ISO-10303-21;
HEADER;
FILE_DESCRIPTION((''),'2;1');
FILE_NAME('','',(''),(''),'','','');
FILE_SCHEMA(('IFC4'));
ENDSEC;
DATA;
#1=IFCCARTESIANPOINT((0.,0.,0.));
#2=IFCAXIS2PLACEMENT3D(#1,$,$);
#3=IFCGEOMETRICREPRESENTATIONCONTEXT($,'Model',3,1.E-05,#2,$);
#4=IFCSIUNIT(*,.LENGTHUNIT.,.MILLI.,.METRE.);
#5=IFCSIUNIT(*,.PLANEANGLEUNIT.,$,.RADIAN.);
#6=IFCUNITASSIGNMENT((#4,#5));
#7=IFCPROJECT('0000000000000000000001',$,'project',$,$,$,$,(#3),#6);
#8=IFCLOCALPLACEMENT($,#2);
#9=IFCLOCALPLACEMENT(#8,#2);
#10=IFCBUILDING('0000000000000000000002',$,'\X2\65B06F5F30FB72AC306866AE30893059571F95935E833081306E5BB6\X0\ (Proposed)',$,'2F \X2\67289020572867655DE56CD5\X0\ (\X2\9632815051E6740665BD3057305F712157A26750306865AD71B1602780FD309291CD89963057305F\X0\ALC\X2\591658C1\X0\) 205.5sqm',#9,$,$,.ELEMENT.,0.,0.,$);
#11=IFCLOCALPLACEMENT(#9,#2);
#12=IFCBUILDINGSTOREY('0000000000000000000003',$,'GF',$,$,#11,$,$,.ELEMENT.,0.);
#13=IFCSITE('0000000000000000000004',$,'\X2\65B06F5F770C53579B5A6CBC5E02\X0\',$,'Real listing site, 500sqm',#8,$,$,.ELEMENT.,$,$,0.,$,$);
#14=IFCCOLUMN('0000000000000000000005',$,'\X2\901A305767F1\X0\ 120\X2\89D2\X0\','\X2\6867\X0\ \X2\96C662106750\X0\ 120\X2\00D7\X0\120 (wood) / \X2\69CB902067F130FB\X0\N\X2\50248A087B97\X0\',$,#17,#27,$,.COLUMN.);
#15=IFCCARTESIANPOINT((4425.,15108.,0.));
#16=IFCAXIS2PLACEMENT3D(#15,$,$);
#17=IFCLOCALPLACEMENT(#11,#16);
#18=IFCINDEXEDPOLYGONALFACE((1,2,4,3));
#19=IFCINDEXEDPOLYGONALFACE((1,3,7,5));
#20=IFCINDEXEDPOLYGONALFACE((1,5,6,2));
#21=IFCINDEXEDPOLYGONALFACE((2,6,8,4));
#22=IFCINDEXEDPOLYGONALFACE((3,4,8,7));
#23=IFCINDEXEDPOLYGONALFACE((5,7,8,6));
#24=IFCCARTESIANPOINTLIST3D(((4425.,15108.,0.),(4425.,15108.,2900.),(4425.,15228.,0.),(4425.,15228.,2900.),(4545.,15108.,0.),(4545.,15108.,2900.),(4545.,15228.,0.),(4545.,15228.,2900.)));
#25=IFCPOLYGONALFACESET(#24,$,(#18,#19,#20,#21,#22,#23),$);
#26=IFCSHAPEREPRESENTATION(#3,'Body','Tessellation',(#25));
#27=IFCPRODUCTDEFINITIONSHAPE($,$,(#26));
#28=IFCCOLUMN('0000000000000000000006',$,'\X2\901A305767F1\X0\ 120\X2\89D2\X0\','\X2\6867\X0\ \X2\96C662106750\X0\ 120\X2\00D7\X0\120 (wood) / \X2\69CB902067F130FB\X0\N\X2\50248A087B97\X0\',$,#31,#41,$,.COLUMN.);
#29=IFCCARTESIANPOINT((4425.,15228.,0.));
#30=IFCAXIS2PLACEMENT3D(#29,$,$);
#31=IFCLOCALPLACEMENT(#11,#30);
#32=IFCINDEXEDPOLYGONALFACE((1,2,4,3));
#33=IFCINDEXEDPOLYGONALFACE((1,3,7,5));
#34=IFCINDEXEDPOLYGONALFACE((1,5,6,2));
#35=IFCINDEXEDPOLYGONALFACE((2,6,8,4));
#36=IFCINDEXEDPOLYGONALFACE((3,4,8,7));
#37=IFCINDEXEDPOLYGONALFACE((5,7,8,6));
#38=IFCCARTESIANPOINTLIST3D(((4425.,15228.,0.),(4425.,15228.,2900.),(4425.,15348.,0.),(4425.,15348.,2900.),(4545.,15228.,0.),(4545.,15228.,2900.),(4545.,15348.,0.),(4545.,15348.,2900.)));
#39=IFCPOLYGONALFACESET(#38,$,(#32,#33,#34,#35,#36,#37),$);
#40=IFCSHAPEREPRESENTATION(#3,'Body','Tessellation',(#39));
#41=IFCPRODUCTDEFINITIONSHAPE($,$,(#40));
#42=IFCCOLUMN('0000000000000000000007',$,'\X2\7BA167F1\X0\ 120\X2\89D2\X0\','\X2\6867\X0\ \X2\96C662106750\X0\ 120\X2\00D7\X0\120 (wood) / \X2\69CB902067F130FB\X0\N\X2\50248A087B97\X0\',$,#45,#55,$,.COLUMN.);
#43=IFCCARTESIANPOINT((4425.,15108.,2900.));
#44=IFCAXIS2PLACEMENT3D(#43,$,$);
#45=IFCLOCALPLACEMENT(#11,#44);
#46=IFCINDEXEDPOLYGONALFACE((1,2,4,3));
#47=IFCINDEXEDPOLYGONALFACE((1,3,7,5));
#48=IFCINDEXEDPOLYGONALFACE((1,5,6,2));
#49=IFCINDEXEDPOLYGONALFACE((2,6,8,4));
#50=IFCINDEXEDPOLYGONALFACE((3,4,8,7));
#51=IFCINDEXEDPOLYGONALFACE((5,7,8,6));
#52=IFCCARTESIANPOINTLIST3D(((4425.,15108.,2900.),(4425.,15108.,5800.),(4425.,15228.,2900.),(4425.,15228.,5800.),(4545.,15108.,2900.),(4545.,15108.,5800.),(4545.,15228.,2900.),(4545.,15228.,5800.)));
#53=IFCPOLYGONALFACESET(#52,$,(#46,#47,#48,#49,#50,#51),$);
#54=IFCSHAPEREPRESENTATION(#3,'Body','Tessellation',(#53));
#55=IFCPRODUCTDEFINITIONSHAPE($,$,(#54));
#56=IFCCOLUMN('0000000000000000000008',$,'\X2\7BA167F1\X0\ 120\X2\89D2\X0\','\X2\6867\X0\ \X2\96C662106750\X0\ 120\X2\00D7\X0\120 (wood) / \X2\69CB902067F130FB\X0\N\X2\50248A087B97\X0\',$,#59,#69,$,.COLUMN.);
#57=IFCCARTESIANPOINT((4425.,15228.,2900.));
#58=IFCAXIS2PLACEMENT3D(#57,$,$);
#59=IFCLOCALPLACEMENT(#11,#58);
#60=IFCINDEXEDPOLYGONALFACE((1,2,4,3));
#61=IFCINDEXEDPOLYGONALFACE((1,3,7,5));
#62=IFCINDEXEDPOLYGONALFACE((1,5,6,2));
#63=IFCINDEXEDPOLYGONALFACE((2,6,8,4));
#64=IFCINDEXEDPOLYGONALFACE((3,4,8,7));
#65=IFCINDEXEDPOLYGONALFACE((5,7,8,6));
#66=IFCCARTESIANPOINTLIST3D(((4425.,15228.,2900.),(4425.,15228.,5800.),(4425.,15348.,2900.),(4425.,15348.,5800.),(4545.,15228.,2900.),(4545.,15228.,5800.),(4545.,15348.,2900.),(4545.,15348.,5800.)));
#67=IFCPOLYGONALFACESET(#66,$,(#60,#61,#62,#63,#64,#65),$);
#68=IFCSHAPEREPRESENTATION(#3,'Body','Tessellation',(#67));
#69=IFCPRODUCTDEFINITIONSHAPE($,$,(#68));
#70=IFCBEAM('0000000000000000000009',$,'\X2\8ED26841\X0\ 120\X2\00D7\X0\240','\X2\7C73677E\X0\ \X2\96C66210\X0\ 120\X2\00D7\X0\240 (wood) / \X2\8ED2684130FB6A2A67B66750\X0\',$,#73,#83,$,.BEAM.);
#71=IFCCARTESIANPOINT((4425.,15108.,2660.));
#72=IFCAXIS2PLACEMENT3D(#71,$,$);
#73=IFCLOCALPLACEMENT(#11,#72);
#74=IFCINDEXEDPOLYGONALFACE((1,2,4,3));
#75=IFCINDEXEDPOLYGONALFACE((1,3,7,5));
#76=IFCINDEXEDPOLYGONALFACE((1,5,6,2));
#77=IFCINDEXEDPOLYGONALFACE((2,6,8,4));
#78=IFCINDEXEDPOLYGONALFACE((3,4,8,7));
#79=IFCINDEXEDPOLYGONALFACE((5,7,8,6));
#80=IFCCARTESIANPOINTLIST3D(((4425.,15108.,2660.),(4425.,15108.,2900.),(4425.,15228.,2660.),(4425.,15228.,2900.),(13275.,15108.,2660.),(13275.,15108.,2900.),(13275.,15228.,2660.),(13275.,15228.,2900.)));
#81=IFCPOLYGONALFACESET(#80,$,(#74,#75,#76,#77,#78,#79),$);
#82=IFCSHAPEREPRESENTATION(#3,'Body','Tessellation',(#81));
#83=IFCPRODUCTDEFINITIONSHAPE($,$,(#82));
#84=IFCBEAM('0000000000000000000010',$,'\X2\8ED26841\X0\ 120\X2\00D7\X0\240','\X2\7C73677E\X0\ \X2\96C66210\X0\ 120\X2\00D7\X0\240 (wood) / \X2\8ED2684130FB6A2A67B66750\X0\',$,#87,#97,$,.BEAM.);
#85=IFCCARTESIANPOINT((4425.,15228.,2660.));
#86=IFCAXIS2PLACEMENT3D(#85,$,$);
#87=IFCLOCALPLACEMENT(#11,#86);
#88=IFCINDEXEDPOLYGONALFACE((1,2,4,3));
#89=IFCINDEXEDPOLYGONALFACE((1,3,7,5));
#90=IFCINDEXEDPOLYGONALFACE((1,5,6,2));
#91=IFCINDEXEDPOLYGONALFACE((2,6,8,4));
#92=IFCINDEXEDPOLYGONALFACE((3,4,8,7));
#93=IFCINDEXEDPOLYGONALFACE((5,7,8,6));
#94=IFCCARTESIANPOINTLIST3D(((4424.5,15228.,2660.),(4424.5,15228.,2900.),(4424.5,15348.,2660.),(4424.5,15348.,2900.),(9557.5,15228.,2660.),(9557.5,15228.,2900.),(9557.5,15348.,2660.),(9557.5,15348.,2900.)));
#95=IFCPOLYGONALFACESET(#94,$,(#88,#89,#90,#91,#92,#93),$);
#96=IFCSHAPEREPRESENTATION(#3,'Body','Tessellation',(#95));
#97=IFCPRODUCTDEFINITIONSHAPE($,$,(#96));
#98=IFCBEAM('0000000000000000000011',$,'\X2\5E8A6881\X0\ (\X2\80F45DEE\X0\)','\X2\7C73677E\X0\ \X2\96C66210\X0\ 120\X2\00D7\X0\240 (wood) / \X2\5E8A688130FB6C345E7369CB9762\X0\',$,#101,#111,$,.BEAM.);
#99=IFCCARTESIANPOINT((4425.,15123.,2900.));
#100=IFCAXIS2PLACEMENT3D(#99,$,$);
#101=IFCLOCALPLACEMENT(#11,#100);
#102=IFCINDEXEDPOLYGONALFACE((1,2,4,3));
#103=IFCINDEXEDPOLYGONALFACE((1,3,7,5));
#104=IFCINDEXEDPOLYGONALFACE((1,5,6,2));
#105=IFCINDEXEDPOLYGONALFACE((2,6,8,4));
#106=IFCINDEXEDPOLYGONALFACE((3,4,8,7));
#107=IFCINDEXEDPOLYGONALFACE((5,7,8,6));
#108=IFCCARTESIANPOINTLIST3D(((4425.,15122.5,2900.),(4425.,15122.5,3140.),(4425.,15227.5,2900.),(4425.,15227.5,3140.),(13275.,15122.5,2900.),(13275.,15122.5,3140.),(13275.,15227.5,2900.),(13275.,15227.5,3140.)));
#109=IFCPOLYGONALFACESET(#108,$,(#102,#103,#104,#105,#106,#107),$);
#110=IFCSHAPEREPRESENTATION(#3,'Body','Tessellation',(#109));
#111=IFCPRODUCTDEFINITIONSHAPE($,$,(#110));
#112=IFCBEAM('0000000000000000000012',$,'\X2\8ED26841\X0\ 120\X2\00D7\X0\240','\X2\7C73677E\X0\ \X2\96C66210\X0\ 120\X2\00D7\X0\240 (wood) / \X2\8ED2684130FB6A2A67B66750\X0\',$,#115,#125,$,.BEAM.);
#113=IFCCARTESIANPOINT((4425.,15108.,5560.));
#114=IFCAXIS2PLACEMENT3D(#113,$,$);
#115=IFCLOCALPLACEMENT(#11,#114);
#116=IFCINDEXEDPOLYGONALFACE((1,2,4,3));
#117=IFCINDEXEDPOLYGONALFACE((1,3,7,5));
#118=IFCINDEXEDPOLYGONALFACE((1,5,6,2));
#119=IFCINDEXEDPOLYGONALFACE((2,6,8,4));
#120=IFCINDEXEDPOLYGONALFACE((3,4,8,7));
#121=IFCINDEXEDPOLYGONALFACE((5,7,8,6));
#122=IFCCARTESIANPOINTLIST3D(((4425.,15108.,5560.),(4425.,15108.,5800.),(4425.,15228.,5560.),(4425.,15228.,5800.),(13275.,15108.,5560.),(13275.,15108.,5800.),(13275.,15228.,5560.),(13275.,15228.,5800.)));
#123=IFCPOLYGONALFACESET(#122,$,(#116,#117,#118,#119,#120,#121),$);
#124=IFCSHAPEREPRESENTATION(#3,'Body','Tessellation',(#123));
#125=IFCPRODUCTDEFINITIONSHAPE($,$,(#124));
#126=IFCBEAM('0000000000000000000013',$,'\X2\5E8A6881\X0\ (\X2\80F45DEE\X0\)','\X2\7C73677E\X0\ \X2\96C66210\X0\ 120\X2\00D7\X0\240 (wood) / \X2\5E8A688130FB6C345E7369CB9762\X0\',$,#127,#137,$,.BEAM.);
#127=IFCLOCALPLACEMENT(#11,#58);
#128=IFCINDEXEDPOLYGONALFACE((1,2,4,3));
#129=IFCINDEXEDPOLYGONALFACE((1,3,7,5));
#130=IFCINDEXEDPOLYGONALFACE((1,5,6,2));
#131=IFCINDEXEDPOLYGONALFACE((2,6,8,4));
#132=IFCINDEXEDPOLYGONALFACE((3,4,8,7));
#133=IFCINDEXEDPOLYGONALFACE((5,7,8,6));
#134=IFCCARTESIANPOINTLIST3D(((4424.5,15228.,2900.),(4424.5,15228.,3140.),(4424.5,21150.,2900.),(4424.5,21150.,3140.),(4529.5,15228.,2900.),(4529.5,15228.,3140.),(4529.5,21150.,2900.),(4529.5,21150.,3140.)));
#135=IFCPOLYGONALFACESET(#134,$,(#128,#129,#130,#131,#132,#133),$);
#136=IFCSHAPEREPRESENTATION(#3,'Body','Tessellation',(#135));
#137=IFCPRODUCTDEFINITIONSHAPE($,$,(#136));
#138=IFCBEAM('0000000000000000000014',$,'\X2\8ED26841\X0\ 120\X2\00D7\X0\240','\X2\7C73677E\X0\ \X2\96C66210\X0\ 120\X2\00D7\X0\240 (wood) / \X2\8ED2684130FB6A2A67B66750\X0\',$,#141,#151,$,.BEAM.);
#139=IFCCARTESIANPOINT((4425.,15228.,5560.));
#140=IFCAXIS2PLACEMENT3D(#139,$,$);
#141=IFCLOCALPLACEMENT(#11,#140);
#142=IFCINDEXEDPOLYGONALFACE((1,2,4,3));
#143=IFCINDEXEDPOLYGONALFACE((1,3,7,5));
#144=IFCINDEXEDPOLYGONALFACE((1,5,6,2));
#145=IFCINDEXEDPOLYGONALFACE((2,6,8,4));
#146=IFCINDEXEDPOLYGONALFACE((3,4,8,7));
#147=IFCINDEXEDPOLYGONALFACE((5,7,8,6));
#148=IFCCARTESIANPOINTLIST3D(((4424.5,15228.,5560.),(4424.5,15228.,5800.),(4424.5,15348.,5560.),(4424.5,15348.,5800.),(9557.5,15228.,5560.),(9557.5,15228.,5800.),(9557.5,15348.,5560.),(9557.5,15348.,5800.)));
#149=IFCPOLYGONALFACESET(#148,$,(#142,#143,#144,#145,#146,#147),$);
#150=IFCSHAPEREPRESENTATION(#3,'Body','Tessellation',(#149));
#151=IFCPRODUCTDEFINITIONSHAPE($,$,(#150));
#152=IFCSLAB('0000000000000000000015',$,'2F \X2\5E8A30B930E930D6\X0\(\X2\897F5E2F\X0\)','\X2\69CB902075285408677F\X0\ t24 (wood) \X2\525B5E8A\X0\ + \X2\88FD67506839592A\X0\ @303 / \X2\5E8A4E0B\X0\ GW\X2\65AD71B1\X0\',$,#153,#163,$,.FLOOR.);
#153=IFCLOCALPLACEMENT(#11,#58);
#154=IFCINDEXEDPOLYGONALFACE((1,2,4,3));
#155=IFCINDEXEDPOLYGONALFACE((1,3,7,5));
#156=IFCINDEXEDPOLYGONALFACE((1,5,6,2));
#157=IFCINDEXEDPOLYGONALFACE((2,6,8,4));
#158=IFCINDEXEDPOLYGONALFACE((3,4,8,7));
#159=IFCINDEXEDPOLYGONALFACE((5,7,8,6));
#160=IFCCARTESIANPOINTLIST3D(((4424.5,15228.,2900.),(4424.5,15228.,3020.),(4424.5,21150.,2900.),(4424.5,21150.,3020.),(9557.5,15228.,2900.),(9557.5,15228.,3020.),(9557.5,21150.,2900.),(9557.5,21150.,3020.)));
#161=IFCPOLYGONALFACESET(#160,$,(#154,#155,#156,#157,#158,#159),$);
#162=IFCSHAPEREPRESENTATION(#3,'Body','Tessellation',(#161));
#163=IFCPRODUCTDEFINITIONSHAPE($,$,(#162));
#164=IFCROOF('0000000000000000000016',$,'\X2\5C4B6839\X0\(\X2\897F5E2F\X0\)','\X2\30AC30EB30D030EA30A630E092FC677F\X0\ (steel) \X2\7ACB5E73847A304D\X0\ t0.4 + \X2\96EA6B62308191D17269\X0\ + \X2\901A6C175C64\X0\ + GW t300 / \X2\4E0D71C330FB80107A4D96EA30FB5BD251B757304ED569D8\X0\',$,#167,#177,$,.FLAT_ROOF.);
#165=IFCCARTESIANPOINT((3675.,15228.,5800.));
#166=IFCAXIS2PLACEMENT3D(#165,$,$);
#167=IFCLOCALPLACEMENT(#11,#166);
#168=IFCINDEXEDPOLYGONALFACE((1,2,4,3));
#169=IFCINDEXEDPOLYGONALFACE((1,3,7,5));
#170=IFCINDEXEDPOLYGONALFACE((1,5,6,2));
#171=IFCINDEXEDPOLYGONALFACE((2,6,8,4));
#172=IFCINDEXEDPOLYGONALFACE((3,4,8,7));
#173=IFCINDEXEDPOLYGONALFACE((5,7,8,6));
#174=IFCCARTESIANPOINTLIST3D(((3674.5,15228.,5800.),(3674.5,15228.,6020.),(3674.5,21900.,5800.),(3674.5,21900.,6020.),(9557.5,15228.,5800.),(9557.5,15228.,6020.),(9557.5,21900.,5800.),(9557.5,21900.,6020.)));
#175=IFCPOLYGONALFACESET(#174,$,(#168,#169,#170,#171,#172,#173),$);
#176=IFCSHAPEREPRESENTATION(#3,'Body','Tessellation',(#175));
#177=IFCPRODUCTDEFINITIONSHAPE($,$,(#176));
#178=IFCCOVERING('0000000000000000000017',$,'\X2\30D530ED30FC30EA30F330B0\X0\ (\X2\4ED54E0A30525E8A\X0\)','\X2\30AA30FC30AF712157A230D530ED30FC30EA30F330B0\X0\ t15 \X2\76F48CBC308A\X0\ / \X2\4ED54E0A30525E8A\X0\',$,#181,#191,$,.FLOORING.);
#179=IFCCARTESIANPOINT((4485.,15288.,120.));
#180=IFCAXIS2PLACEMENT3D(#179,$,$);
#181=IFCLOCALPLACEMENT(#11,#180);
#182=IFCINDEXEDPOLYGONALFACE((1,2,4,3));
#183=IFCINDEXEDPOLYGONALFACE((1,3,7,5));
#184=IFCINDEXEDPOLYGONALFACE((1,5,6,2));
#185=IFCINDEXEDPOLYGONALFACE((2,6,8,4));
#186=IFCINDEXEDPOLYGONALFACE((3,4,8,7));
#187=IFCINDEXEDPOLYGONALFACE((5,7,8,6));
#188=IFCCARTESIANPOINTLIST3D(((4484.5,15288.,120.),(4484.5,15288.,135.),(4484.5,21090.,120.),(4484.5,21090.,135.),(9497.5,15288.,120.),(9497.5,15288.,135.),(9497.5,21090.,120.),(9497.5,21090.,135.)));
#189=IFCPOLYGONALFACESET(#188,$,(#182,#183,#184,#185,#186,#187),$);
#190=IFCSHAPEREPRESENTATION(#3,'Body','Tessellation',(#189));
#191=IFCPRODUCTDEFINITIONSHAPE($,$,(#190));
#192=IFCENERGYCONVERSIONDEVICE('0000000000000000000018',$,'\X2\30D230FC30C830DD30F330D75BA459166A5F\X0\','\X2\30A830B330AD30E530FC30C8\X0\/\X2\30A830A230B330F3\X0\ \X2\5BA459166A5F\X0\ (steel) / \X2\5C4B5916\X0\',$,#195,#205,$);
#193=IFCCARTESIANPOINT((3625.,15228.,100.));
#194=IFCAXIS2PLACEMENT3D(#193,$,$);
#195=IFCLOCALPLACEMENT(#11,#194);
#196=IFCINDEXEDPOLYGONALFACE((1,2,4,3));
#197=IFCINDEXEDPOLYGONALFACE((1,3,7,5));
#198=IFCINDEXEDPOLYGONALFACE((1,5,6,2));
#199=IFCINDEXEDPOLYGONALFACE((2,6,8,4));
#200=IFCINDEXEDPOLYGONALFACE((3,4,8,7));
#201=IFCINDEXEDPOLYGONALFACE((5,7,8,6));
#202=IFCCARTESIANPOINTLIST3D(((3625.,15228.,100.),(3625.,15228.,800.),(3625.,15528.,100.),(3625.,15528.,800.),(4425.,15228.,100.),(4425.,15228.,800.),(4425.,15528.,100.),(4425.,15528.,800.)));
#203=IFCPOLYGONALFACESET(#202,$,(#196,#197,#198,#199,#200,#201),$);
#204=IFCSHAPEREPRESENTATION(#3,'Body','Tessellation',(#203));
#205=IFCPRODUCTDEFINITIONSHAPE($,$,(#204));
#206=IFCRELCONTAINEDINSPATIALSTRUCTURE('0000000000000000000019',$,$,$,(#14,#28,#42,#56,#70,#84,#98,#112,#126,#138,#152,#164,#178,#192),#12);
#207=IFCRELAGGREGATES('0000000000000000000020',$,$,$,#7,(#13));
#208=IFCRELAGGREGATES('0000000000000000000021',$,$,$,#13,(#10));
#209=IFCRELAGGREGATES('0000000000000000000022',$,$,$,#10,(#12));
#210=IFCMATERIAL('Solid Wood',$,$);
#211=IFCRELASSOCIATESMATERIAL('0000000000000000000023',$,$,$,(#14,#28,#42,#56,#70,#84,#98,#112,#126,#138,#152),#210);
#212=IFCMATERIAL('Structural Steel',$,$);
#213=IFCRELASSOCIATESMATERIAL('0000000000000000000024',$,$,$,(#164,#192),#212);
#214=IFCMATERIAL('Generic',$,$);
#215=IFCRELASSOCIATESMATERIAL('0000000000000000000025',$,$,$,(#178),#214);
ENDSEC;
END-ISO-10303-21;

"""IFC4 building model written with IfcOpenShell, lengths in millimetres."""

from ifc_helpers import new_model, si_unit, frame, frame_2d, origin, place, context, project, spatial, rectangle, extrude, material, element, save


model = new_model("IFC4")

# Units and contexts
model_context = context("Model", 3, precision=1e-05, world=origin())
ifc_project = project(units=[si_unit("LENGTHUNIT", "METRE", prefix="MILLI"), si_unit("PLANEANGLEUNIT", "RADIAN")], contexts=[model_context])

# Site, building, storey
site_placement = place(None, origin())
site = spatial("IfcSite", under=ifc_project, at=site_placement, Name="新潟県南魚沼市", ObjectType="Real listing site, 500sqm", CompositionType="ELEMENT", RefElevation=0.0)
building_placement = place(site_placement, origin())
building = spatial("IfcBuilding", under=site, at=building_placement, Name="新潟・犬と暮らす土間広めの家 (Proposed)", ObjectType="2F 木造在来工法 (防腐処理施した無垢材と断熱性能を重視したALC外壁) 205.5sqm", CompositionType="ELEMENT", ElevationOfRefHeight=0.0, ElevationOfTerrain=0.0)
storey_placement = place(building_placement, origin())
storey = spatial("IfcBuildingStorey", under=building, at=storey_placement, Name="GF", CompositionType="ELEMENT", Elevation=0.0)

# Columns
ifc_material_1 = material(Name="Solid Wood")
column_1_placement = place(storey_placement, frame((4425.0, 15108.0, 0.0)))
element("IfcColumn", 1, at=column_1_placement, inside=storey, material=ifc_material_1, Name="通し柱 120角", Description="桧 集成材 120×120 (wood) / 構造柱・N値計算", PredefinedType="COLUMN", context=model_context, shape_type="SweptSolid", body=[
    extrude(rectangle(XDim=120.0, YDim=120.0, at=frame_2d((60.0, 60.0))), frame((4425.0, 15108.0, 0.0)), (0.0, 0.0, 1.0), 2900.0),
])
column_2_placement = place(storey_placement, frame((4425.0, 15228.0, 0.0)))
element("IfcColumn", 2, at=column_2_placement, inside=storey, material=ifc_material_1, Name="通し柱 120角", Description="桧 集成材 120×120 (wood) / 構造柱・N値計算", PredefinedType="COLUMN", context=model_context, shape_type="SweptSolid", body=[
    extrude(rectangle(XDim=120.0, YDim=120.0, at=frame_2d((60.0, 60.0))), frame((4425.0, 15228.0, 0.0)), (0.0, 0.0, 1.0), 2900.0),
])
column_3_placement = place(storey_placement, frame((4425.0, 15108.0, 2900.0)))
element("IfcColumn", 3, at=column_3_placement, inside=storey, material=ifc_material_1, Name="管柱 120角", Description="桧 集成材 120×120 (wood) / 構造柱・N値計算", PredefinedType="COLUMN", context=model_context, shape_type="SweptSolid", body=[
    extrude(rectangle(XDim=120.0, YDim=120.0, at=frame_2d((60.0, 60.0))), frame((4425.0, 15108.0, 2900.0)), (0.0, 0.0, 1.0), 2900.0),
])
column_4_placement = place(storey_placement, frame((4425.0, 15228.0, 2900.0)))
element("IfcColumn", 4, at=column_4_placement, inside=storey, material=ifc_material_1, Name="管柱 120角", Description="桧 集成材 120×120 (wood) / 構造柱・N値計算", PredefinedType="COLUMN", context=model_context, shape_type="SweptSolid", body=[
    extrude(rectangle(XDim=120.0, YDim=120.0, at=frame_2d((60.0, 60.0))), frame((4425.0, 15228.0, 2900.0)), (0.0, 0.0, 1.0), 2900.0),
])

# Beams
beam_1_placement = place(storey_placement, frame((4425.0, 15108.0, 2660.0)))
element("IfcBeam", 5, at=beam_1_placement, inside=storey, material=ifc_material_1, Name="軒桁 120×240", Description="米松 集成 120×240 (wood) / 軒桁・横架材", PredefinedType="BEAM", context=model_context, shape_type="SweptSolid", body=[
    extrude(rectangle(XDim=8850.0, YDim=120.0, at=frame_2d((4425.0, 60.0))), frame((4425.0, 15108.0, 2660.0)), (0.0, 0.0, 1.0), 240.0),
])
beam_2_placement = place(storey_placement, frame((4425.0, 15228.0, 2660.0)))
element("IfcBeam", 6, at=beam_2_placement, inside=storey, material=ifc_material_1, Name="軒桁 120×240", Description="米松 集成 120×240 (wood) / 軒桁・横架材", PredefinedType="BEAM", context=model_context, shape_type="SweptSolid", body=[
    extrude(rectangle(XDim=5133.0, YDim=120.0, at=frame_2d((2566.0, 60.0))), frame((4425.0, 15228.0, 2660.0)), (0.0, 0.0, 1.0), 240.0),
])
beam_3_placement = place(storey_placement, frame((4425.0, 15123.0, 2900.0)))
element("IfcBeam", 7, at=beam_3_placement, inside=storey, material=ifc_material_1, Name="床梁 (胴差)", Description="米松 集成 120×240 (wood) / 床梁・水平構面", PredefinedType="BEAM", context=model_context, shape_type="SweptSolid", body=[
    extrude(rectangle(XDim=8850.0, YDim=105.0, at=frame_2d((4425.0, 52.0))), frame((4425.0, 15123.0, 2900.0)), (0.0, 0.0, 1.0), 240.0),
])
beam_4_placement = place(storey_placement, frame((4425.0, 15108.0, 5560.0)))
element("IfcBeam", 8, at=beam_4_placement, inside=storey, material=ifc_material_1, Name="軒桁 120×240", Description="米松 集成 120×240 (wood) / 軒桁・横架材", PredefinedType="BEAM", context=model_context, shape_type="SweptSolid", body=[
    extrude(rectangle(XDim=8850.0, YDim=120.0, at=frame_2d((4425.0, 60.0))), frame((4425.0, 15108.0, 5560.0)), (0.0, 0.0, 1.0), 240.0),
])
beam_5_placement = place(storey_placement, frame((4425.0, 15228.0, 2900.0)))
element("IfcBeam", 9, at=beam_5_placement, inside=storey, material=ifc_material_1, Name="床梁 (胴差)", Description="米松 集成 120×240 (wood) / 床梁・水平構面", PredefinedType="BEAM", context=model_context, shape_type="SweptSolid", body=[
    extrude(rectangle(XDim=105.0, YDim=5922.0, at=frame_2d((52.0, 2961.0))), frame((4425.0, 15228.0, 2900.0)), (0.0, 0.0, 1.0), 240.0),
])
beam_6_placement = place(storey_placement, frame((4425.0, 15228.0, 5560.0)))
element("IfcBeam", 10, at=beam_6_placement, inside=storey, material=ifc_material_1, Name="軒桁 120×240", Description="米松 集成 120×240 (wood) / 軒桁・横架材", PredefinedType="BEAM", context=model_context, shape_type="SweptSolid", body=[
    extrude(rectangle(XDim=5133.0, YDim=120.0, at=frame_2d((2566.0, 60.0))), frame((4425.0, 15228.0, 5560.0)), (0.0, 0.0, 1.0), 240.0),
])

# Slab
slab_1_placement = place(storey_placement, frame((4425.0, 15228.0, 2900.0)))
element("IfcSlab", 11, at=slab_1_placement, inside=storey, material=ifc_material_1, Name="2F 床スラブ(西帯)", Description="構造用合板 t24 (wood) 剛床 + 製材根太 @303 / 床下 GW断熱", PredefinedType="FLOOR", context=model_context, shape_type="SweptSolid", body=[
    extrude(rectangle(XDim=5133.0, YDim=5922.0, at=frame_2d((2566.0, 2961.0))), frame((4425.0, 15228.0, 2900.0)), (0.0, 0.0, 1.0), 120.0),
])

# Roof
ifc_material_2 = material(Name="Structural Steel")
for number, where, name in (
    (12, (3675.0, 15228.0, 5800.0), "屋根(西帯)"),
):
    element("IfcRoof", number, at=place(storey_placement, frame(where)), inside=storey, material=ifc_material_2, Name=name, Description="ガルバリウム鋼板 (steel) 立平葺き t0.4 + 雪止め金物 + 通気層 + GW t300 / 不燃・耐積雪・寒冷地仕様", PredefinedType="FLAT_ROOF", context=model_context, shape_type="SweptSolid", body=[
        extrude(rectangle(XDim=5883.0, YDim=6672.0, at=frame_2d((2941.0, 3336.0))), frame((3675.0, 15228.0, 5800.0)), (0.0, 0.0, 1.0), 220.0),
    ])

# Covering
ifc_material_3 = material(Name="Generic")
covering_placement = place(storey_placement, frame((4485.0, 15288.0, 120.0)))
element("IfcCovering", 13, at=covering_placement, inside=storey, material=ifc_material_3, Name="フローリング (仕上げ床)", Description="オーク無垢フローリング t15 直貼り / 仕上げ床", PredefinedType="FLOORING", context=model_context, shape_type="SweptSolid", body=[
    extrude(rectangle(XDim=5013.0, YDim=5802.0, at=frame_2d((2506.0, 2901.0))), frame((4485.0, 15288.0, 120.0)), (0.0, 0.0, 1.0), 15.0),
])

# Energy conversion device
energy_conversion_device_placement = place(storey_placement, frame((3625.0, 15228.0, 100.0)))
element("IfcEnergyConversionDevice", 14, at=energy_conversion_device_placement, inside=storey, material=ifc_material_2, Name="ヒートポンプ室外機", Description="エコキュート/エアコン 室外機 (steel) / 屋外", context=model_context, shape_type="SweptSolid", body=[
    extrude(rectangle(XDim=800.0, YDim=300.0, at=frame_2d((400.0, 150.0))), frame((3625.0, 15228.0, 100.0)), (0.0, 0.0, 1.0), 700.0),
])

save(model, "model.ifc")
